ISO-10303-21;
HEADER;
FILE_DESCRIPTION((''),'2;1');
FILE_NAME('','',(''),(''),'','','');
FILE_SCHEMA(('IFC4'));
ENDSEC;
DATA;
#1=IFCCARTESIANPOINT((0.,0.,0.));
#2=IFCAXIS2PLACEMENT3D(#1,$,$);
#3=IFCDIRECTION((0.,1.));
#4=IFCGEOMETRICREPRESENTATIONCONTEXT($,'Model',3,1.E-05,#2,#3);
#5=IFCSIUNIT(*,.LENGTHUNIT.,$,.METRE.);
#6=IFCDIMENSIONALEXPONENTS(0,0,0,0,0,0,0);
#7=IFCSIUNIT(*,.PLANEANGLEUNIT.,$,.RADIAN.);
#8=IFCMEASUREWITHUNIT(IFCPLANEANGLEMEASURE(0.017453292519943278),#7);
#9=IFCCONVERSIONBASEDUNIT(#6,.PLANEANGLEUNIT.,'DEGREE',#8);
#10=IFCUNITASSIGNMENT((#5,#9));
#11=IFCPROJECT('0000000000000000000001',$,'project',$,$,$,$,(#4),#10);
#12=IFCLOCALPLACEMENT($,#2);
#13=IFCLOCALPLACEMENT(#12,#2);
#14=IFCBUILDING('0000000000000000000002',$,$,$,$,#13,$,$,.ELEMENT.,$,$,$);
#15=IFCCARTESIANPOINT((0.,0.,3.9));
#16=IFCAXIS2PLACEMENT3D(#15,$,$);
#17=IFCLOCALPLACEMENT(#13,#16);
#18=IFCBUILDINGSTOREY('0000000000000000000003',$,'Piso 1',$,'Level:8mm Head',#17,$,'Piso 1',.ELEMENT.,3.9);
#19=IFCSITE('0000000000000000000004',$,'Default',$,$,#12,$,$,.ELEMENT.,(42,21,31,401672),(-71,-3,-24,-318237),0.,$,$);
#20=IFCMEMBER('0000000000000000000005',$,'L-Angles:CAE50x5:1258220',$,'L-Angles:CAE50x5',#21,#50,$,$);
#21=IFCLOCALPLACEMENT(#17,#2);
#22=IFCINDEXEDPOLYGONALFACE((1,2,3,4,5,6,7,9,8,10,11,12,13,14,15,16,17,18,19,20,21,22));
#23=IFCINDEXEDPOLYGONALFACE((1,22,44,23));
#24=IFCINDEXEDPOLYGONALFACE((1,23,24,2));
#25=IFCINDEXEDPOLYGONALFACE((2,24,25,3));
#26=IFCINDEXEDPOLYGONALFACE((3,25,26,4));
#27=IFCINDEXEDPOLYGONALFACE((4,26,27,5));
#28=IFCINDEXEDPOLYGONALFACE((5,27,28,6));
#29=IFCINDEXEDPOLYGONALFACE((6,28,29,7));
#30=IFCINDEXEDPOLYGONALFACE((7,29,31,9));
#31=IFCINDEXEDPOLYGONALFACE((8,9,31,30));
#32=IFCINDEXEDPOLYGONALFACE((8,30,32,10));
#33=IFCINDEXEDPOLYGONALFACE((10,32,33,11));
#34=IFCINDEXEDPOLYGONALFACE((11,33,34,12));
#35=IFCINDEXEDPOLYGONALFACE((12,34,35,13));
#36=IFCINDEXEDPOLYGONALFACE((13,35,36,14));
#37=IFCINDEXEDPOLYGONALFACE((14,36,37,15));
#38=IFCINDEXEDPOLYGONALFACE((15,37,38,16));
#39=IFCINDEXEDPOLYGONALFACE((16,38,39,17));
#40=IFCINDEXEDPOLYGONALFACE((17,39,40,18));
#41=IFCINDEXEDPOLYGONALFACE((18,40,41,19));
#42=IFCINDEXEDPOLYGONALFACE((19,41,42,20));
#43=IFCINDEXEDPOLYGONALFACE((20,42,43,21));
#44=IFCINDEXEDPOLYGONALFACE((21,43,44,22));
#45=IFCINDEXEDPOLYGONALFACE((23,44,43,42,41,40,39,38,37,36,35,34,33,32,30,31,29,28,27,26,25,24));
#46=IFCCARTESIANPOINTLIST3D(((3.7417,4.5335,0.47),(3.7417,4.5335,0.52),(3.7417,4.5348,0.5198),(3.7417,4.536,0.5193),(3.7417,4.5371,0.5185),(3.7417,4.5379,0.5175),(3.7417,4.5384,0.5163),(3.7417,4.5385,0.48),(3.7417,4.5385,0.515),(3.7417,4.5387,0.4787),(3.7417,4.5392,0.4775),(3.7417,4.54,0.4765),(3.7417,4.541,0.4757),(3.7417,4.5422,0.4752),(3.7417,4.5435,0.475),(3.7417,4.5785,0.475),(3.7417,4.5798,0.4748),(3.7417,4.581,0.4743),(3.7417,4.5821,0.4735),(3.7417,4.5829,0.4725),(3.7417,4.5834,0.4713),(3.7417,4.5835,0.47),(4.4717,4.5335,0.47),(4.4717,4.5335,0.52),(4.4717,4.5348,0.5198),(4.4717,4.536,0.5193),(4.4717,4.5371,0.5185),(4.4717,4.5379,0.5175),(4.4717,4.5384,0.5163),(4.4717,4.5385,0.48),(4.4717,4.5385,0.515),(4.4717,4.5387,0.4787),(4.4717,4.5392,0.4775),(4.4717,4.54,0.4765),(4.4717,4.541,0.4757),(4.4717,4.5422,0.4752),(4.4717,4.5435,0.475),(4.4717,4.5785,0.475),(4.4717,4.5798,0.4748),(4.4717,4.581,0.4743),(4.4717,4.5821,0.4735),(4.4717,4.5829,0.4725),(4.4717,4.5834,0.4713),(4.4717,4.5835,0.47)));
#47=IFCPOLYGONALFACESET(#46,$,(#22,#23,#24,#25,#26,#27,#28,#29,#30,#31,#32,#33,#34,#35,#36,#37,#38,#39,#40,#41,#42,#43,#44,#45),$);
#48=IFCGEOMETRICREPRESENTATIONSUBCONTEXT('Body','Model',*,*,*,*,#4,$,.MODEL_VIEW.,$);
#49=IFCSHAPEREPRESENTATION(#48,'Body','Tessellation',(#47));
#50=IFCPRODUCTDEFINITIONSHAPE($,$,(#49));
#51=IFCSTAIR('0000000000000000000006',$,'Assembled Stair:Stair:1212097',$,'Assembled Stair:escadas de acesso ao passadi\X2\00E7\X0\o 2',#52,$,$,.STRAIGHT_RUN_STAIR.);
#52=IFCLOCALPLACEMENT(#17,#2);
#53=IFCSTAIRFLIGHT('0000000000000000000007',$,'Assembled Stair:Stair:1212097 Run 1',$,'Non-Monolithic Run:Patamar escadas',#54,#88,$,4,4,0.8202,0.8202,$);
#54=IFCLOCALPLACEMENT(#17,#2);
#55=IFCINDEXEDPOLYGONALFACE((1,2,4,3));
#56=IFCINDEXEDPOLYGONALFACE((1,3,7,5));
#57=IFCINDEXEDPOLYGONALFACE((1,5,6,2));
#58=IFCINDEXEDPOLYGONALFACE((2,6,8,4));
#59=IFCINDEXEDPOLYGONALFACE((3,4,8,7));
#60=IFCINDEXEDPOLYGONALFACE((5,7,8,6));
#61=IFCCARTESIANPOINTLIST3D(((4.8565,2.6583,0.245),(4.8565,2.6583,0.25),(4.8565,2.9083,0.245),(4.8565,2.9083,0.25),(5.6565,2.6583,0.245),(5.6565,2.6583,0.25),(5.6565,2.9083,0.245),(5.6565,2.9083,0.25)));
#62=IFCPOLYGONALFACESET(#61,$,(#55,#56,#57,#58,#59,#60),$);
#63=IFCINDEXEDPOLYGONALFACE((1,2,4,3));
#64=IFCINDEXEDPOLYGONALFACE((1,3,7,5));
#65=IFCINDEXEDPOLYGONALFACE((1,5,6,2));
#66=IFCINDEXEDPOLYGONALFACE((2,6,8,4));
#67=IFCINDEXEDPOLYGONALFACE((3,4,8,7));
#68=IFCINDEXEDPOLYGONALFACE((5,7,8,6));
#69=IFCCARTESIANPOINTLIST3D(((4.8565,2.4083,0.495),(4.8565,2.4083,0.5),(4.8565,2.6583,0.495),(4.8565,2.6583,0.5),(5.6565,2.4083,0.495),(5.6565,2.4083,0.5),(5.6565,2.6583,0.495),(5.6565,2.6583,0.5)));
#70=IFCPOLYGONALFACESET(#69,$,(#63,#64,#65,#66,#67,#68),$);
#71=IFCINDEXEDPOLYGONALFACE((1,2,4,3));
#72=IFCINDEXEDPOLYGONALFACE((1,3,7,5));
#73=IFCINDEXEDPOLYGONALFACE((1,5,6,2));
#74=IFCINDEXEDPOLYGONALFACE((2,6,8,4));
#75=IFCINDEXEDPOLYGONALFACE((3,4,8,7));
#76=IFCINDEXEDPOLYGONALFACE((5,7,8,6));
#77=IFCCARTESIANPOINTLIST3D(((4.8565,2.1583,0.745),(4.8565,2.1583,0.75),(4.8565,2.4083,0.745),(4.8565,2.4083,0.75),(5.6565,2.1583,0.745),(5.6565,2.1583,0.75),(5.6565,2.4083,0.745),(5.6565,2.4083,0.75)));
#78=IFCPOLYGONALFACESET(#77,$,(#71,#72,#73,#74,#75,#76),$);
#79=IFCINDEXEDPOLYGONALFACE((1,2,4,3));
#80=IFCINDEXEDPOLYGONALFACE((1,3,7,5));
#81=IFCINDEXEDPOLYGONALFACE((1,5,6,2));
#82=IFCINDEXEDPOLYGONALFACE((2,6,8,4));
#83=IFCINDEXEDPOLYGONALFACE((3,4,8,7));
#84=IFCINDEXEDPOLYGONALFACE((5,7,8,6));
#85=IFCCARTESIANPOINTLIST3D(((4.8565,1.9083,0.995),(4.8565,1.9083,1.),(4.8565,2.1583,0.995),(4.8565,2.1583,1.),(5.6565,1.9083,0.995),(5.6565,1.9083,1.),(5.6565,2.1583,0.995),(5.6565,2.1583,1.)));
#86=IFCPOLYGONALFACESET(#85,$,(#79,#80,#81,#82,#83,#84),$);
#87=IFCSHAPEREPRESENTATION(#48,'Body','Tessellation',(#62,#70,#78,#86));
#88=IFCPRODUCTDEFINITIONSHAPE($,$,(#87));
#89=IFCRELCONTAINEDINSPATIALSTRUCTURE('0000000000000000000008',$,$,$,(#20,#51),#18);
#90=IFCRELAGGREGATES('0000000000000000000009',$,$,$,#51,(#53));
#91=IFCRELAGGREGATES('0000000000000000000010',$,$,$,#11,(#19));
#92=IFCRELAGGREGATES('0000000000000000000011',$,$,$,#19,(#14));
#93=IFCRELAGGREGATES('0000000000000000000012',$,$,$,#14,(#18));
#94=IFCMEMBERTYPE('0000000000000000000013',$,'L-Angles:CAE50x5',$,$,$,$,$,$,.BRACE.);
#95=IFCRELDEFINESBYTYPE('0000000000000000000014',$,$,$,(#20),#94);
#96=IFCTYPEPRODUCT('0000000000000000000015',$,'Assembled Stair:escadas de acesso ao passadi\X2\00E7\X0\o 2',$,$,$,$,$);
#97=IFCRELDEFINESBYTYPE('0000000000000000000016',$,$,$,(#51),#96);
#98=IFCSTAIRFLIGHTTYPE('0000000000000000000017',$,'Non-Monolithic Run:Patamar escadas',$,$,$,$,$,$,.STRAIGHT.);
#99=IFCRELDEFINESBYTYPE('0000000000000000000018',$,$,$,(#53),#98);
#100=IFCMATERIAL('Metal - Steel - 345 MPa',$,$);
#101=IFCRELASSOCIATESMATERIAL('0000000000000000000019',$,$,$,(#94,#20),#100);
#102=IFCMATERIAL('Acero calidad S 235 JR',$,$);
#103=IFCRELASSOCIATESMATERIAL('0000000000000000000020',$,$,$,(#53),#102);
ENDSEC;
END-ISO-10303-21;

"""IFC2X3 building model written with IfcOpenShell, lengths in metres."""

from ifc_helpers import new_model, entity, si_unit, converted_unit, direction, frame, frame_2d, origin, place, context, subcontext, project, spatial, polyline, circle_curve, parameter, trimmed, segment, composite_curve, rectangle, outline, extrude, source, transform, mapped, material, type_object, type_shapes, element, aggregate, save


model = new_model("IFC2X3")

# Units and contexts
model_context = context("Model", 3, precision=1e-05, world=origin(), true_north=direction((0.0, 1.0)))
body_context = subcontext(model_context, "Body", "Model", "MODEL_VIEW")
ifc_project = project(units=[si_unit("LENGTHUNIT", "METRE"), converted_unit("PLANEANGLEUNIT", "DEGREE", entity("IfcPlaneAngleMeasure", 0.017453292519943278), si_unit("PLANEANGLEUNIT", "RADIAN"), dimensions=[0, 0, 0, 0, 0, 0, 0])], contexts=[model_context])

# Site, building, storey
site_placement = place(None, origin())
site = spatial("IfcSite", under=ifc_project, at=site_placement, Name="Default", CompositionType="ELEMENT", RefLatitude=(42, 21, 31, 401672), RefLongitude=(-71, -3, -24, -318237), RefElevation=0.0)
building_placement = place(site_placement, origin())
building = spatial("IfcBuilding", under=site, at=building_placement, CompositionType="ELEMENT")
storey_placement = place(building_placement, frame((0.0, 0.0, 3.9)))
storey = spatial("IfcBuildingStorey", under=building, at=storey_placement, Name="Piso 1", ObjectType="Level:8mm Head", LongName="Piso 1", CompositionType="ELEMENT", Elevation=3.9)

# Shared definitions
ifc_material_1 = material(Name="Metal - Steel - 345 MPa")

# Member
member_type_1 = type_object("IfcMemberType", Name="L-Angles:CAE50x5", PredefinedType="BRACE", material=ifc_material_1)
shared_shape_1 = source(origin(), body_context, "Body", "SweptSolid", [
    extrude(outline(composite_curve([segment(polyline([(-0.0164, -0.0164), (0.0336, -0.0164)]), True, "CONTINUOUS"), segment(trimmed(circle_curve(frame_2d((0.0286, -0.0164), x_axis=(1.0, 0.0)), 0.005), [parameter(0.0)], [parameter(90.0)], True, "PARAMETER"), True, "CONTINUOUS"), segment(polyline([(0.0286, -0.0114), (-0.0064, -0.0114)]), True, "CONTINUOUS"), segment(trimmed(circle_curve(frame_2d((-0.0064, -0.0064), x_axis=(1.0, 0.0)), 0.005), [parameter(180.0)], [parameter(270.0)], True, "PARAMETER"), False, "CONTINUOUS"), segment(polyline([(-0.0114, -0.0064), (-0.0114, 0.0286)]), True, "CONTINUOUS"), segment(trimmed(circle_curve(frame_2d((-0.0164, 0.0286), x_axis=(1.0, 0.0)), 0.005), [parameter(0.0)], [parameter(90.0)], True, "PARAMETER"), True, "CONTINUOUS"), segment(polyline([(-0.0164, 0.0336), (-0.0164, -0.0164)]), True, "CONTINUOUS")], self_intersect=False)), frame((-0.365, -0.0024, -0.0024), z_axis=(1.0, 0.0, 0.0), x_axis=(0.0, -1.0, 0.0)), (0.0, 0.0, 1.0), 0.73),
])
type_shapes(member_type_1, [shared_shape_1])
for number, where, z_axis, x_axis, name in (
    (1, (4.1067, 4.5475, 0.484), (0.0, -1.0, 0.0), (-1.0, 0.0, 0.0), "L-Angles:CAE50x5:1258220"),
):
    element("IfcMember", number, at=place(storey_placement, frame(where, z_axis=z_axis, x_axis=x_axis)), inside=storey, type_object=member_type_1, material=ifc_material_1, Name=name, ObjectType="L-Angles:CAE50x5", context=body_context, shape_type="MappedRepresentation", body=[
        mapped(shared_shape_1, transform((0.0, 0.0, 0.0), scale=1.0)),
    ])

# Stair, stair flight
type_product = type_object("IfcTypeProduct", Name="Assembled Stair:escadas de acesso ao passadiço 2")
stair_placement = place(storey_placement, origin())
stair = element("IfcStair", 2, at=stair_placement, inside=storey, type_object=type_product, Name="Assembled Stair:Stair:1212097", ObjectType="Assembled Stair:escadas de acesso ao passadiço 2", ShapeType="STRAIGHT_RUN_STAIR")
ifc_material_2 = material(Name="Acero calidad S 235 JR")
stair_flight_type = type_object("IfcStairFlightType", Name="Non-Monolithic Run:Patamar escadas", PredefinedType="STRAIGHT")
stair_flight_placement = place(stair_placement, frame((4.8565, 1.9083, 0.0)))
stair_flight = element("IfcStairFlight", 3, at=stair_flight_placement, type_object=stair_flight_type, material=ifc_material_2, Name="Assembled Stair:Stair:1212097 Run 1", ObjectType="Non-Monolithic Run:Patamar escadas", NumberOfRiser=4, NumberOfTreads=4, RiserHeight=0.8202, TreadLength=0.8202, context=body_context, shape_type="SweptSolid", body=[
    extrude(rectangle(XDim=0.25, YDim=0.8, at=frame_2d((0.0, 0.0), x_axis=(1.0, 0.0))), frame((0.4, 0.875, 0.245), z_axis=(0.0, 0.0, 1.0), x_axis=(0.0, 1.0, 0.0)), (0.0, 0.0, 1.0), 0.005),
    extrude(rectangle(XDim=0.25, YDim=0.8, at=frame_2d((0.0, 0.0), x_axis=(1.0, 0.0))), frame((0.4, 0.625, 0.495), z_axis=(0.0, 0.0, 1.0), x_axis=(0.0, 1.0, 0.0)), (0.0, 0.0, 1.0), 0.005),
    extrude(rectangle(XDim=0.25, YDim=0.8, at=frame_2d((0.0, 0.0), x_axis=(1.0, 0.0))), frame((0.4, 0.375, 0.745), z_axis=(0.0, 0.0, 1.0), x_axis=(0.0, 1.0, 0.0)), (0.0, 0.0, 1.0), 0.005),
    extrude(rectangle(XDim=0.25, YDim=0.8, at=frame_2d((0.0, 0.0), x_axis=(1.0, 0.0))), frame((0.4, 0.125, 0.995), z_axis=(0.0, 0.0, 1.0), x_axis=(0.0, 1.0, 0.0)), (0.0, 0.0, 1.0), 0.005),
])
aggregate(stair, [stair_flight])

save(model, "model.ifc")
